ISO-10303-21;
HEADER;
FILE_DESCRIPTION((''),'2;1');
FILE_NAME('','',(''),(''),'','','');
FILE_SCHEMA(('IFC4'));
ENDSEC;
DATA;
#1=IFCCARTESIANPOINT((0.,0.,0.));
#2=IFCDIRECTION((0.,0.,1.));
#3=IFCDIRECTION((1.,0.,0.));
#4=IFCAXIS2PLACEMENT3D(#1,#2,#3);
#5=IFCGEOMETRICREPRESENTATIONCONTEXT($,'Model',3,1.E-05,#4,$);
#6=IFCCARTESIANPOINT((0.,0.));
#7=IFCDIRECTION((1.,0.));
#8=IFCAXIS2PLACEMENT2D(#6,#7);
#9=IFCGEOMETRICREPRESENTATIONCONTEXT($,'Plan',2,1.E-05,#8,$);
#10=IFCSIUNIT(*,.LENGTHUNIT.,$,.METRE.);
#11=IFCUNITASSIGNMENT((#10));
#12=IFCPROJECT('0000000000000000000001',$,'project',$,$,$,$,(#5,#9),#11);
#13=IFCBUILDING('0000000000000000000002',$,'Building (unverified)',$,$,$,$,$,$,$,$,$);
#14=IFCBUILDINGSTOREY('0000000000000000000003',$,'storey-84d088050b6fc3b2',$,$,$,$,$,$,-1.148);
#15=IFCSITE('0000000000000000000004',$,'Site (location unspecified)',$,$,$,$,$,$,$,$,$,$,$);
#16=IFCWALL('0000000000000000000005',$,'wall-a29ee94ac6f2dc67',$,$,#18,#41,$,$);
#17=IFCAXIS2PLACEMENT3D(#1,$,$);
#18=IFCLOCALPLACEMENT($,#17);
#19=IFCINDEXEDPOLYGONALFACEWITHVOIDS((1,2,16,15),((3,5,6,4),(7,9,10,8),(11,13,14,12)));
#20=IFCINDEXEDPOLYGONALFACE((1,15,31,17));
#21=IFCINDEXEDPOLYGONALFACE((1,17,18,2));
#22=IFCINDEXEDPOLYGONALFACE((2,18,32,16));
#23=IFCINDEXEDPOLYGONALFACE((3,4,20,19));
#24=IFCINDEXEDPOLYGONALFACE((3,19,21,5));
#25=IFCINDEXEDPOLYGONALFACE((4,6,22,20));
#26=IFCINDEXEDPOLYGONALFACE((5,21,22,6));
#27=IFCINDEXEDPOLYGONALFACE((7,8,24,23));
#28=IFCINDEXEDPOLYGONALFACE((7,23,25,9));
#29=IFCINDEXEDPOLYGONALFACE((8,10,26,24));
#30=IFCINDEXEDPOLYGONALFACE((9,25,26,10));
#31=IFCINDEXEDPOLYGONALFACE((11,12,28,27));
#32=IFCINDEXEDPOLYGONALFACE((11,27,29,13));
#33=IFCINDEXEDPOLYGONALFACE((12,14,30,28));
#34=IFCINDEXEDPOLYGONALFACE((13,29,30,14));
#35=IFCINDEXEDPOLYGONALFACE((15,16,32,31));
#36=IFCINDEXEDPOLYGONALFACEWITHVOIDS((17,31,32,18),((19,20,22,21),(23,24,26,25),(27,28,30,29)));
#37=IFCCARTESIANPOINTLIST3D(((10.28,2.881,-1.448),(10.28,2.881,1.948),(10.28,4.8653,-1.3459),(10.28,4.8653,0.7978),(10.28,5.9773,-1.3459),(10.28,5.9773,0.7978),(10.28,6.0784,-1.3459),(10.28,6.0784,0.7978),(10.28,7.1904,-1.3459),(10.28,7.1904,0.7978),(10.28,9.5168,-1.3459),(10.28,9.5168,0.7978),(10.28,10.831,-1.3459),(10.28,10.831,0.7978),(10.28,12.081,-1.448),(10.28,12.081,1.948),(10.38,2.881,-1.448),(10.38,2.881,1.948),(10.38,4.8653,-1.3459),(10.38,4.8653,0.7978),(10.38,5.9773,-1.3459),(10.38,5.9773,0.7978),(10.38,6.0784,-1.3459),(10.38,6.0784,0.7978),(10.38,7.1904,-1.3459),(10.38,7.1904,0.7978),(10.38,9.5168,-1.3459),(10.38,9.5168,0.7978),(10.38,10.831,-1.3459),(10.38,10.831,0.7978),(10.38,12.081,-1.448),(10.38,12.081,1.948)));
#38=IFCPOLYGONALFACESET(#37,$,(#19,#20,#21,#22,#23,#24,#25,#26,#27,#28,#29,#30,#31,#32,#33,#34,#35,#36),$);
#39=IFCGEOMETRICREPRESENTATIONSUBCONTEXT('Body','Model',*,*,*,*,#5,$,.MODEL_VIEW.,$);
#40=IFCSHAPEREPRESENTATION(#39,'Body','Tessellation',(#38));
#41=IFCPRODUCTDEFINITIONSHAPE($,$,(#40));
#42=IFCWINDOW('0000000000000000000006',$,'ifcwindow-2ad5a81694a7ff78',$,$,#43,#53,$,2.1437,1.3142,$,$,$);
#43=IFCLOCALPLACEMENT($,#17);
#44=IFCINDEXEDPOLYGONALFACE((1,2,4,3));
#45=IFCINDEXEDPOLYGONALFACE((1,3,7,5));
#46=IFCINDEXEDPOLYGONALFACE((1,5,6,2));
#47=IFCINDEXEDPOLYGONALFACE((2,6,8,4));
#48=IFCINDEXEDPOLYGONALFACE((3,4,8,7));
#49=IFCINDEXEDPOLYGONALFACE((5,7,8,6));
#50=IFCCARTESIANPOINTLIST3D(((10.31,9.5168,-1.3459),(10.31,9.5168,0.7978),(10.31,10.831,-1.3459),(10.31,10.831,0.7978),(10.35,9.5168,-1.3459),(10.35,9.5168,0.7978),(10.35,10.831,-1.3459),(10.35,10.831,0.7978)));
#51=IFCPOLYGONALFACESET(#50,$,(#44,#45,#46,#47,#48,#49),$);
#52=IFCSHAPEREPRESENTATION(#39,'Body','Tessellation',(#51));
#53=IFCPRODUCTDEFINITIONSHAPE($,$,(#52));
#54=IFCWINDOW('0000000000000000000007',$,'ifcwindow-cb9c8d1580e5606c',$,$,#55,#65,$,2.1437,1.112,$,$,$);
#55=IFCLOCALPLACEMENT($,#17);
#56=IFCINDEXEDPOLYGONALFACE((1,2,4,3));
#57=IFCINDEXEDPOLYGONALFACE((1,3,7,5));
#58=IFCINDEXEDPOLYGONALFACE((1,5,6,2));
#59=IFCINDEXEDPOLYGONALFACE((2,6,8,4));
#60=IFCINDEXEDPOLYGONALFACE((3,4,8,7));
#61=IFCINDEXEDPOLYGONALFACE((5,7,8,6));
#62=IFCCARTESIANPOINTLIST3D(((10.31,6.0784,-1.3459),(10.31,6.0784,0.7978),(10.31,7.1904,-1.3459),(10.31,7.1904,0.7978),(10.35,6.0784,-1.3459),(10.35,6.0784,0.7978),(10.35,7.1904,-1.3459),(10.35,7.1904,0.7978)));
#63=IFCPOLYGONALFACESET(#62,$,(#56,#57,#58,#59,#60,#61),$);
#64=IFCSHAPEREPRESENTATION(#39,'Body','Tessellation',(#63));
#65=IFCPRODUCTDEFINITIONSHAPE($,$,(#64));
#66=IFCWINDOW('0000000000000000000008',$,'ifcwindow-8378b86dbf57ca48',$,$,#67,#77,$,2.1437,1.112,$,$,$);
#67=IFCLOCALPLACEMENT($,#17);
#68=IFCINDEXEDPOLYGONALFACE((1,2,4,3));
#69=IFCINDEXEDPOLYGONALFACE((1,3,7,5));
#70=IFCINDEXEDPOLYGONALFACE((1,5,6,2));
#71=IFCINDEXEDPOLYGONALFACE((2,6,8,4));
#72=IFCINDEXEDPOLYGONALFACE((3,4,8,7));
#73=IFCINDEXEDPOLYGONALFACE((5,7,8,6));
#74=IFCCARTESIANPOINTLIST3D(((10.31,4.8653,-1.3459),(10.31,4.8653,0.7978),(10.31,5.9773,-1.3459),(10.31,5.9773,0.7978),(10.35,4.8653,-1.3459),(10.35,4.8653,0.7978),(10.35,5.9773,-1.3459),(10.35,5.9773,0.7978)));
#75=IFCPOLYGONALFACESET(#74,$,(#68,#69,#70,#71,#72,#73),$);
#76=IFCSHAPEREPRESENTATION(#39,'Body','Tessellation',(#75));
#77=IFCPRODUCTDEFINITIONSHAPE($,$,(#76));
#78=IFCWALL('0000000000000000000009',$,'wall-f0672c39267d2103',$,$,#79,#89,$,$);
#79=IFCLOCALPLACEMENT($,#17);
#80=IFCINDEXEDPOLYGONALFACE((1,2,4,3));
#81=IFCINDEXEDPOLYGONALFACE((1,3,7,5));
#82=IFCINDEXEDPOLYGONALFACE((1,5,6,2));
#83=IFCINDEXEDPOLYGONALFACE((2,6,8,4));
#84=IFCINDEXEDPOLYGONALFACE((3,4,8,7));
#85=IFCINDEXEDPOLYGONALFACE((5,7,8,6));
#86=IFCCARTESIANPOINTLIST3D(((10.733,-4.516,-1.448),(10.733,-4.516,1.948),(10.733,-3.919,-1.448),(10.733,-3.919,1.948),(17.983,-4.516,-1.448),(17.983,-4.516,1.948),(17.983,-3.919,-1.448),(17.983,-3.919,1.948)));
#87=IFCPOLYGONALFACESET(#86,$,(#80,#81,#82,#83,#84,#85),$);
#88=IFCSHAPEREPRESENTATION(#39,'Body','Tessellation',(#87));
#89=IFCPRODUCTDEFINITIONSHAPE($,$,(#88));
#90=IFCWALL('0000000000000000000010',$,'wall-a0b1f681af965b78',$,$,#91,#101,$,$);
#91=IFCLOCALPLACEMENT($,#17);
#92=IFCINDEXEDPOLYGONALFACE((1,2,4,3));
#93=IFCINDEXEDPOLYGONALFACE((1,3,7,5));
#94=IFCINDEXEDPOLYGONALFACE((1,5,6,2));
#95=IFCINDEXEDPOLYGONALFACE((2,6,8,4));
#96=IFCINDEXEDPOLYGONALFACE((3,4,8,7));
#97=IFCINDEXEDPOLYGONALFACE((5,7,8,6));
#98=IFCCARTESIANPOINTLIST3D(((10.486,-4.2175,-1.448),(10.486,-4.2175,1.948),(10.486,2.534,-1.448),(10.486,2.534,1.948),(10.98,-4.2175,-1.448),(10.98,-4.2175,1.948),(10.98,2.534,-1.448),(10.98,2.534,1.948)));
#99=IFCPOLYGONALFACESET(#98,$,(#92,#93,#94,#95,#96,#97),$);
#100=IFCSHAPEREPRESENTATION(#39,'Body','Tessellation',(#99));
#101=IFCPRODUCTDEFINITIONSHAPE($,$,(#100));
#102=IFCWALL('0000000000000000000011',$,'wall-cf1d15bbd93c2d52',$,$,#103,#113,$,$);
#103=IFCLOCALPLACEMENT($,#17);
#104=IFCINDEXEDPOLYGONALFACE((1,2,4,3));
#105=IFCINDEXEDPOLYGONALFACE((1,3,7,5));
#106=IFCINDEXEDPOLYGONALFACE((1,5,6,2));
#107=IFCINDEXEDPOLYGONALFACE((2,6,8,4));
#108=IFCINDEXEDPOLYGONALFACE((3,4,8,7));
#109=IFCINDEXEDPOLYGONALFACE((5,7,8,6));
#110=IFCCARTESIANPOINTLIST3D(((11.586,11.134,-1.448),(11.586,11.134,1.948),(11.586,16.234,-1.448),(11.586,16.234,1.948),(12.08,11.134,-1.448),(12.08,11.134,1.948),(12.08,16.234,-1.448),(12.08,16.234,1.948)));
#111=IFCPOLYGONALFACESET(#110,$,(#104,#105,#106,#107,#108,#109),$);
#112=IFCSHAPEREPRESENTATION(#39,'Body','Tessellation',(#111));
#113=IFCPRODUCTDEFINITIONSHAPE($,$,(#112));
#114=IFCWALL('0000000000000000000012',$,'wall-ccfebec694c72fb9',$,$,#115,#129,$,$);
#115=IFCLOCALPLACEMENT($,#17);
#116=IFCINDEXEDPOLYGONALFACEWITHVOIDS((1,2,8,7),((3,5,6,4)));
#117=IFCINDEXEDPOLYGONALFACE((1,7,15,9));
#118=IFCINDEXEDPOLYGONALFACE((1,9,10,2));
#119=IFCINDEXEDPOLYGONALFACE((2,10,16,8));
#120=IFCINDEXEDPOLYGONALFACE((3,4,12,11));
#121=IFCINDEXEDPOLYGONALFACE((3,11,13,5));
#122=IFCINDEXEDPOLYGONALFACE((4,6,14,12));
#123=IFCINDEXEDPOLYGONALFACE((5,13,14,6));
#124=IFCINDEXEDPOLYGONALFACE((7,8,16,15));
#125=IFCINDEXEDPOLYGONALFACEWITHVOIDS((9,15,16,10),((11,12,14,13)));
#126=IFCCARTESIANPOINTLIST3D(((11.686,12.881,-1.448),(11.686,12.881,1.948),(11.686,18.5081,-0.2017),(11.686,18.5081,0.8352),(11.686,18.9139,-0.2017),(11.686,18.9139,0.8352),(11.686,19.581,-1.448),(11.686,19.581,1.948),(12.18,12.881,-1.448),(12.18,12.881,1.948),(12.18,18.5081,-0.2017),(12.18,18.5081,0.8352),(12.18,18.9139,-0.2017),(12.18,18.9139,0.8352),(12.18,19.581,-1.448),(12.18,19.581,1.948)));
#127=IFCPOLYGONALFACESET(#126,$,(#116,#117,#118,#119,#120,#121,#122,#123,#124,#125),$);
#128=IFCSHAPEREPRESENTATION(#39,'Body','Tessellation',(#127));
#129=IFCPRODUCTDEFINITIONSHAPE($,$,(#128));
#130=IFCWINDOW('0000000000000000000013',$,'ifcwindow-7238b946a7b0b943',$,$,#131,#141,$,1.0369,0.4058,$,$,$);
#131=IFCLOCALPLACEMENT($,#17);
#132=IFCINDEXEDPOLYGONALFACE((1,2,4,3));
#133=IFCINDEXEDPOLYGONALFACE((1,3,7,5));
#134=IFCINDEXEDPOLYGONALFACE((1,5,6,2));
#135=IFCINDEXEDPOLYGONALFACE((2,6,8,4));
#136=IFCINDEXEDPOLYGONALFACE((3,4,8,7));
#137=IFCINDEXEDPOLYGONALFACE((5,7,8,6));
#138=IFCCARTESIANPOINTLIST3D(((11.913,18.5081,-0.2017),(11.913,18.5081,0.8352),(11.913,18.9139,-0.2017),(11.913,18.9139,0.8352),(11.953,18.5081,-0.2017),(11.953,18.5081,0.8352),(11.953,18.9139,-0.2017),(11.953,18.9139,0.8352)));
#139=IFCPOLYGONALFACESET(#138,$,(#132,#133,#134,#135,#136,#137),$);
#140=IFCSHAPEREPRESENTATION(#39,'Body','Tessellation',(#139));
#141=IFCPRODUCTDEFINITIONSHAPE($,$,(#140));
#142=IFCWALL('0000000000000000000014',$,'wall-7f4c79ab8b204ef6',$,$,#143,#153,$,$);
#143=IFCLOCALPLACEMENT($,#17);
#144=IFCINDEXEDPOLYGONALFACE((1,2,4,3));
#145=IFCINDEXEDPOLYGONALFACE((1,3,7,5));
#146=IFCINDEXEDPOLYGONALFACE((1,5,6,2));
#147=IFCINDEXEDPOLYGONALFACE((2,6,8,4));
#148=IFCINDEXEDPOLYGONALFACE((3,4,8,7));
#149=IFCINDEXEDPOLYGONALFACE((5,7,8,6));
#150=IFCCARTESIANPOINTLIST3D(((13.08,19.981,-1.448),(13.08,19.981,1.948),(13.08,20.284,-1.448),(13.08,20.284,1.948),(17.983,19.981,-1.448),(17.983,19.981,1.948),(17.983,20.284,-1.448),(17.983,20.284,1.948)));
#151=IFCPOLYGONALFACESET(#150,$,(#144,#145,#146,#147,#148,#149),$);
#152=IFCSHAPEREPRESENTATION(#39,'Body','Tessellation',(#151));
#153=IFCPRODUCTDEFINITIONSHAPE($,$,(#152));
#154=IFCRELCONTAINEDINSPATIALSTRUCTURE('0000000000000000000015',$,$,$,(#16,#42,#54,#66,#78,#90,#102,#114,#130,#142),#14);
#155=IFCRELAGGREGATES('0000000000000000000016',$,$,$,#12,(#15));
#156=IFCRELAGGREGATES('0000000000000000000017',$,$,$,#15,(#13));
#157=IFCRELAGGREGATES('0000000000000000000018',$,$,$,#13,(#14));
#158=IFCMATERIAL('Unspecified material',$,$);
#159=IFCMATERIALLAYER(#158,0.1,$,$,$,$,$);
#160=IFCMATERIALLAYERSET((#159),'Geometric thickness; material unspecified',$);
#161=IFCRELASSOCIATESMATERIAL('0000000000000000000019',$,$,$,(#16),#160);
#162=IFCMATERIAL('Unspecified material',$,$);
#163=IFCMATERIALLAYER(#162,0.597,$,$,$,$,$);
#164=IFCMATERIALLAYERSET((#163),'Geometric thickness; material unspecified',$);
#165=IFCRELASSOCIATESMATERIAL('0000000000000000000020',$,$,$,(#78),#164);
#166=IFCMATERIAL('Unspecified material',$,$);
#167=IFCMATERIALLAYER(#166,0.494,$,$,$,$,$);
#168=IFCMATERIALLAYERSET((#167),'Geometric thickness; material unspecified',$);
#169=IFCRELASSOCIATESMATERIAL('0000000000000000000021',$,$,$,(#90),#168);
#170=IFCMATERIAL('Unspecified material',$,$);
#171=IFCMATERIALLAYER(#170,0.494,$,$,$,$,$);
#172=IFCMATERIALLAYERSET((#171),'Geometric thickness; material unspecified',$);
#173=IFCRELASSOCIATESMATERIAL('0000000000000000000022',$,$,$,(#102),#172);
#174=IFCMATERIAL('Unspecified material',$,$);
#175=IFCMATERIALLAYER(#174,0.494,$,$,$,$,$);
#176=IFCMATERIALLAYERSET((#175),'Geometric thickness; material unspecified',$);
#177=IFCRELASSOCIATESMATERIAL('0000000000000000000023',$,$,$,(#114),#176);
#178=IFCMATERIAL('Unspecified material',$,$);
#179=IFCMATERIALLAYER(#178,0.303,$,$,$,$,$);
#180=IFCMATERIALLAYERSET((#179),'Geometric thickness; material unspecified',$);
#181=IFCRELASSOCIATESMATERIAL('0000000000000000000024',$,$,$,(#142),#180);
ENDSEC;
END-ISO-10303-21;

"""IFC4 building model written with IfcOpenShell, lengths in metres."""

from ifc_helpers import new_model, si_unit, frame, origin_with_axes, origin_2d_with_axis, place, context, subcontext, project, spatial, indexed_curve, outline, extrude, material, layer, layer_set, layer_usage, element, fill, save


model = new_model("IFC4")

# Units and contexts
model_context = context("Model", 3, precision=1e-05, world=origin_with_axes())
plan_context = context("Plan", 2, precision=1e-05, world=origin_2d_with_axis())
body_context = subcontext(model_context, "Body", "Model", "MODEL_VIEW")
ifc_project = project(units=[si_unit("LENGTHUNIT", "METRE")], contexts=[model_context, plan_context])

# Site, building, storey
site = spatial("IfcSite", under=ifc_project, Name="Site (location unspecified)")
building = spatial("IfcBuilding", under=site, Name="Building (unverified)")
storey = spatial("IfcBuildingStorey", under=building, Name="storey-84d088050b6fc3b2", Elevation=-1.148)

# Wall, openings, windows
ifc_material_1 = material(Name="Unspecified material")
ifc_layer_1 = layer(ifc_material_1, 0.1)
ifc_layer_set_1 = layer_set([ifc_layer_1], Name="Geometric thickness; material unspecified")
ifc_layer_usage_1 = layer_usage(ifc_layer_set_1, "AXIS2", "POSITIVE", -0.05)
wall_1_placement = place(None, frame((10.33, 12.081, -1.448), z_axis=(0.0, 0.0, 1.0), x_axis=(0.0, -1.0, 0.0)))
wall_1 = element("IfcWall", 1, at=wall_1_placement, inside=storey, material=ifc_layer_usage_1, Name="wall-a29ee94ac6f2dc67", context=body_context, shape_type="SweptSolid", body=[
    extrude(outline(indexed_curve([(0.0, 0.0), (0.0, 0.1), (9.2, 0.1), (9.2, 0.0), (0.0, 0.0)], self_intersect=False)), frame((0.0, -0.05, 0.0), z_axis=(0.0, 0.0, 1.0), x_axis=(1.0, 0.0, 0.0)), (0.0, 0.0, 1.0), 3.396),
])
opening_1_placement = place(wall_1_placement, frame((1.25, -0.06, 0.1021), z_axis=(0.0, 0.0, 1.0), x_axis=(1.0, 0.0, 0.0)))
opening_1 = element("IfcOpeningElement", 2, at=opening_1_placement, cuts=wall_1, context=body_context, shape_type="SweptSolid", body=[
    extrude(outline(indexed_curve([(0.0, 0.0), (0.0, 0.12), (1.3142, 0.12), (1.3142, 0.0), (0.0, 0.0)], self_intersect=False)), origin_with_axes(), (0.0, 0.0, 1.0), 2.1437),
])
opening_2_placement = place(wall_1_placement, frame((4.8906, -0.06, 0.1021), z_axis=(0.0, 0.0, 1.0), x_axis=(1.0, 0.0, 0.0)))
opening_2 = element("IfcOpeningElement", 3, at=opening_2_placement, cuts=wall_1, context=body_context, shape_type="SweptSolid", body=[
    extrude(outline(indexed_curve([(0.0, 0.0), (0.0, 0.12), (1.112, 0.12), (1.112, 0.0), (0.0, 0.0)], self_intersect=False)), origin_with_axes(), (0.0, 0.0, 1.0), 2.1437),
])
opening_3_placement = place(wall_1_placement, frame((6.1037, -0.06, 0.1021), z_axis=(0.0, 0.0, 1.0), x_axis=(1.0, 0.0, 0.0)))
opening_3 = element("IfcOpeningElement", 4, at=opening_3_placement, cuts=wall_1, context=body_context, shape_type="SweptSolid", body=[
    extrude(outline(indexed_curve([(0.0, 0.0), (0.0, 0.12), (1.112, 0.12), (1.112, 0.0), (0.0, 0.0)], self_intersect=False)), origin_with_axes(), (0.0, 0.0, 1.0), 2.1437),
])
window_1_placement = place(opening_1_placement, frame((0.0, 0.04, 0.0), z_axis=(0.0, 0.0, 1.0), x_axis=(1.0, 0.0, 0.0)))
window_1 = element("IfcWindow", 5, at=window_1_placement, inside=storey, Name="ifcwindow-2ad5a81694a7ff78", OverallHeight=2.1437, OverallWidth=1.3142, context=body_context, shape_type="SweptSolid", body=[
    extrude(outline(indexed_curve([(0.0, 0.0), (0.0, 0.04), (1.3142, 0.04), (1.3142, 0.0), (0.0, 0.0)], self_intersect=False)), origin_with_axes(), (0.0, 0.0, 1.0), 2.1437),
])
fill(opening_1, window_1)
window_2_placement = place(None, frame((10.31, 7.1904, -1.3459), z_axis=(0.0, 0.0, 1.0), x_axis=(0.0, -1.0, 0.0)))
window_2 = element("IfcWindow", 6, at=window_2_placement, inside=storey, Name="ifcwindow-cb9c8d1580e5606c", OverallHeight=2.1437, OverallWidth=1.112, context=body_context, shape_type="SweptSolid", body=[
    extrude(outline(indexed_curve([(0.0, 0.0), (0.0, 0.04), (1.112, 0.04), (1.112, 0.0), (0.0, 0.0)], self_intersect=False)), origin_with_axes(), (0.0, 0.0, 1.0), 2.1437),
])
fill(opening_2, window_2)
window_3_placement = place(None, frame((10.31, 5.9773, -1.3459), z_axis=(0.0, 0.0, 1.0), x_axis=(0.0, -1.0, 0.0)))
window_3 = element("IfcWindow", 7, at=window_3_placement, inside=storey, Name="ifcwindow-8378b86dbf57ca48", OverallHeight=2.1437, OverallWidth=1.112, context=body_context, shape_type="SweptSolid", body=[
    extrude(outline(indexed_curve([(0.0, 0.0), (0.0, 0.04), (1.112, 0.04), (1.112, 0.0), (0.0, 0.0)], self_intersect=False)), origin_with_axes(), (0.0, 0.0, 1.0), 2.1437),
])
fill(opening_3, window_3)

# Walls
ifc_material_2 = material(Name="Unspecified material")
ifc_layer_2 = layer(ifc_material_2, 0.597)
ifc_layer_set_2 = layer_set([ifc_layer_2], Name="Geometric thickness; material unspecified")
ifc_layer_usage_2 = layer_usage(ifc_layer_set_2, "AXIS2", "POSITIVE", -0.2985)
wall_2_placement = place(None, frame((17.983, -4.2175, -1.448), z_axis=(0.0, 0.0, 1.0), x_axis=(-1.0, 0.0, 0.0)))
element("IfcWall", 8, at=wall_2_placement, inside=storey, material=ifc_layer_usage_2, Name="wall-f0672c39267d2103", context=body_context, shape_type="SweptSolid", body=[
    extrude(outline(indexed_curve([(0.0, 0.0), (0.0, 0.597), (7.25, 0.597), (7.25, 0.0), (0.0, 0.0)], self_intersect=False)), frame((0.0, -0.2985, 0.0), z_axis=(0.0, 0.0, 1.0), x_axis=(1.0, 0.0, 0.0)), (0.0, 0.0, 1.0), 3.396),
])
ifc_material_3 = material(Name="Unspecified material")
ifc_layer_3 = layer(ifc_material_3, 0.494)
ifc_layer_set_3 = layer_set([ifc_layer_3], Name="Geometric thickness; material unspecified")
ifc_layer_usage_3 = layer_usage(ifc_layer_set_3, "AXIS2", "POSITIVE", -0.247)
wall_3_placement = place(None, frame((10.733, -4.2175, -1.448), z_axis=(0.0, 0.0, 1.0), x_axis=(0.0, 1.0, 0.0)))
element("IfcWall", 9, at=wall_3_placement, inside=storey, material=ifc_layer_usage_3, Name="wall-a0b1f681af965b78", context=body_context, shape_type="SweptSolid", body=[
    extrude(outline(indexed_curve([(0.0, 0.0), (0.0, 0.494), (6.7515, 0.494), (6.7515, 0.0), (0.0, 0.0)], self_intersect=False)), frame((0.0, -0.247, 0.0), z_axis=(0.0, 0.0, 1.0), x_axis=(1.0, 0.0, 0.0)), (0.0, 0.0, 1.0), 3.396),
])
ifc_material_4 = material(Name="Unspecified material")
ifc_layer_4 = layer(ifc_material_4, 0.494)
ifc_layer_set_4 = layer_set([ifc_layer_4], Name="Geometric thickness; material unspecified")
ifc_layer_usage_4 = layer_usage(ifc_layer_set_4, "AXIS2", "POSITIVE", -0.247)
wall_4_placement = place(None, frame((11.833, 11.134, -1.448), z_axis=(0.0, 0.0, 1.0), x_axis=(0.0, 1.0, 0.0)))
element("IfcWall", 10, at=wall_4_placement, inside=storey, material=ifc_layer_usage_4, Name="wall-cf1d15bbd93c2d52", context=body_context, shape_type="SweptSolid", body=[
    extrude(outline(indexed_curve([(0.0, 0.0), (0.0, 0.494), (5.1, 0.494), (5.1, 0.0), (0.0, 0.0)], self_intersect=False)), frame((0.0, -0.247, 0.0), z_axis=(0.0, 0.0, 1.0), x_axis=(1.0, 0.0, 0.0)), (0.0, 0.0, 1.0), 3.396),
])

# Wall, opening, window
ifc_material_5 = material(Name="Unspecified material")
ifc_layer_5 = layer(ifc_material_5, 0.494)
ifc_layer_set_5 = layer_set([ifc_layer_5], Name="Geometric thickness; material unspecified")
ifc_layer_usage_5 = layer_usage(ifc_layer_set_5, "AXIS2", "POSITIVE", -0.247)
wall_5_placement = place(None, frame((11.933, 12.881, -1.448), z_axis=(0.0, 0.0, 1.0), x_axis=(0.0, 1.0, 0.0)))
wall_5 = element("IfcWall", 11, at=wall_5_placement, inside=storey, material=ifc_layer_usage_5, Name="wall-ccfebec694c72fb9", context=body_context, shape_type="SweptSolid", body=[
    extrude(outline(indexed_curve([(0.0, 0.0), (0.0, 0.494), (6.7, 0.494), (6.7, 0.0), (0.0, 0.0)], self_intersect=False)), frame((0.0, -0.247, 0.0), z_axis=(0.0, 0.0, 1.0), x_axis=(1.0, 0.0, 0.0)), (0.0, 0.0, 1.0), 3.396),
])
opening_4_placement = place(wall_5_placement, frame((5.6271, -0.257, 1.2463), z_axis=(0.0, 0.0, 1.0), x_axis=(1.0, 0.0, 0.0)))
opening_4 = element("IfcOpeningElement", 12, at=opening_4_placement, cuts=wall_5, context=body_context, shape_type="SweptSolid", body=[
    extrude(outline(indexed_curve([(0.0, 0.0), (0.0, 0.514), (0.4058, 0.514), (0.4058, 0.0), (0.0, 0.0)], self_intersect=False)), origin_with_axes(), (0.0, 0.0, 1.0), 1.0369),
])
window_4_placement = place(None, frame((11.953, 18.5081, -0.2017), z_axis=(0.0, 0.0, 1.0), x_axis=(0.0, 1.0, 0.0)))
window_4 = element("IfcWindow", 13, at=window_4_placement, inside=storey, Name="ifcwindow-7238b946a7b0b943", OverallHeight=1.0369, OverallWidth=0.4058, context=body_context, shape_type="SweptSolid", body=[
    extrude(outline(indexed_curve([(0.0, 0.0), (0.0, 0.04), (0.4058, 0.04), (0.4058, 0.0), (0.0, 0.0)], self_intersect=False)), origin_with_axes(), (0.0, 0.0, 1.0), 1.0369),
])
fill(opening_4, window_4)

# Wall
ifc_material_6 = material(Name="Unspecified material")
ifc_layer_6 = layer(ifc_material_6, 0.303)
ifc_layer_set_6 = layer_set([ifc_layer_6], Name="Geometric thickness; material unspecified")
ifc_layer_usage_6 = layer_usage(ifc_layer_set_6, "AXIS2", "POSITIVE", -0.1515)
wall_6_placement = place(None, frame((13.08, 20.1325, -1.448), z_axis=(0.0, 0.0, 1.0), x_axis=(1.0, 0.0, 0.0)))
element("IfcWall", 14, at=wall_6_placement, inside=storey, material=ifc_layer_usage_6, Name="wall-7f4c79ab8b204ef6", context=body_context, shape_type="SweptSolid", body=[
    extrude(outline(indexed_curve([(0.0, 0.0), (0.0, 0.303), (4.903, 0.303), (4.903, 0.0), (0.0, 0.0)], self_intersect=False)), frame((0.0, -0.1515, 0.0), z_axis=(0.0, 0.0, 1.0), x_axis=(1.0, 0.0, 0.0)), (0.0, 0.0, 1.0), 3.396),
])

save(model, "model.ifc")
